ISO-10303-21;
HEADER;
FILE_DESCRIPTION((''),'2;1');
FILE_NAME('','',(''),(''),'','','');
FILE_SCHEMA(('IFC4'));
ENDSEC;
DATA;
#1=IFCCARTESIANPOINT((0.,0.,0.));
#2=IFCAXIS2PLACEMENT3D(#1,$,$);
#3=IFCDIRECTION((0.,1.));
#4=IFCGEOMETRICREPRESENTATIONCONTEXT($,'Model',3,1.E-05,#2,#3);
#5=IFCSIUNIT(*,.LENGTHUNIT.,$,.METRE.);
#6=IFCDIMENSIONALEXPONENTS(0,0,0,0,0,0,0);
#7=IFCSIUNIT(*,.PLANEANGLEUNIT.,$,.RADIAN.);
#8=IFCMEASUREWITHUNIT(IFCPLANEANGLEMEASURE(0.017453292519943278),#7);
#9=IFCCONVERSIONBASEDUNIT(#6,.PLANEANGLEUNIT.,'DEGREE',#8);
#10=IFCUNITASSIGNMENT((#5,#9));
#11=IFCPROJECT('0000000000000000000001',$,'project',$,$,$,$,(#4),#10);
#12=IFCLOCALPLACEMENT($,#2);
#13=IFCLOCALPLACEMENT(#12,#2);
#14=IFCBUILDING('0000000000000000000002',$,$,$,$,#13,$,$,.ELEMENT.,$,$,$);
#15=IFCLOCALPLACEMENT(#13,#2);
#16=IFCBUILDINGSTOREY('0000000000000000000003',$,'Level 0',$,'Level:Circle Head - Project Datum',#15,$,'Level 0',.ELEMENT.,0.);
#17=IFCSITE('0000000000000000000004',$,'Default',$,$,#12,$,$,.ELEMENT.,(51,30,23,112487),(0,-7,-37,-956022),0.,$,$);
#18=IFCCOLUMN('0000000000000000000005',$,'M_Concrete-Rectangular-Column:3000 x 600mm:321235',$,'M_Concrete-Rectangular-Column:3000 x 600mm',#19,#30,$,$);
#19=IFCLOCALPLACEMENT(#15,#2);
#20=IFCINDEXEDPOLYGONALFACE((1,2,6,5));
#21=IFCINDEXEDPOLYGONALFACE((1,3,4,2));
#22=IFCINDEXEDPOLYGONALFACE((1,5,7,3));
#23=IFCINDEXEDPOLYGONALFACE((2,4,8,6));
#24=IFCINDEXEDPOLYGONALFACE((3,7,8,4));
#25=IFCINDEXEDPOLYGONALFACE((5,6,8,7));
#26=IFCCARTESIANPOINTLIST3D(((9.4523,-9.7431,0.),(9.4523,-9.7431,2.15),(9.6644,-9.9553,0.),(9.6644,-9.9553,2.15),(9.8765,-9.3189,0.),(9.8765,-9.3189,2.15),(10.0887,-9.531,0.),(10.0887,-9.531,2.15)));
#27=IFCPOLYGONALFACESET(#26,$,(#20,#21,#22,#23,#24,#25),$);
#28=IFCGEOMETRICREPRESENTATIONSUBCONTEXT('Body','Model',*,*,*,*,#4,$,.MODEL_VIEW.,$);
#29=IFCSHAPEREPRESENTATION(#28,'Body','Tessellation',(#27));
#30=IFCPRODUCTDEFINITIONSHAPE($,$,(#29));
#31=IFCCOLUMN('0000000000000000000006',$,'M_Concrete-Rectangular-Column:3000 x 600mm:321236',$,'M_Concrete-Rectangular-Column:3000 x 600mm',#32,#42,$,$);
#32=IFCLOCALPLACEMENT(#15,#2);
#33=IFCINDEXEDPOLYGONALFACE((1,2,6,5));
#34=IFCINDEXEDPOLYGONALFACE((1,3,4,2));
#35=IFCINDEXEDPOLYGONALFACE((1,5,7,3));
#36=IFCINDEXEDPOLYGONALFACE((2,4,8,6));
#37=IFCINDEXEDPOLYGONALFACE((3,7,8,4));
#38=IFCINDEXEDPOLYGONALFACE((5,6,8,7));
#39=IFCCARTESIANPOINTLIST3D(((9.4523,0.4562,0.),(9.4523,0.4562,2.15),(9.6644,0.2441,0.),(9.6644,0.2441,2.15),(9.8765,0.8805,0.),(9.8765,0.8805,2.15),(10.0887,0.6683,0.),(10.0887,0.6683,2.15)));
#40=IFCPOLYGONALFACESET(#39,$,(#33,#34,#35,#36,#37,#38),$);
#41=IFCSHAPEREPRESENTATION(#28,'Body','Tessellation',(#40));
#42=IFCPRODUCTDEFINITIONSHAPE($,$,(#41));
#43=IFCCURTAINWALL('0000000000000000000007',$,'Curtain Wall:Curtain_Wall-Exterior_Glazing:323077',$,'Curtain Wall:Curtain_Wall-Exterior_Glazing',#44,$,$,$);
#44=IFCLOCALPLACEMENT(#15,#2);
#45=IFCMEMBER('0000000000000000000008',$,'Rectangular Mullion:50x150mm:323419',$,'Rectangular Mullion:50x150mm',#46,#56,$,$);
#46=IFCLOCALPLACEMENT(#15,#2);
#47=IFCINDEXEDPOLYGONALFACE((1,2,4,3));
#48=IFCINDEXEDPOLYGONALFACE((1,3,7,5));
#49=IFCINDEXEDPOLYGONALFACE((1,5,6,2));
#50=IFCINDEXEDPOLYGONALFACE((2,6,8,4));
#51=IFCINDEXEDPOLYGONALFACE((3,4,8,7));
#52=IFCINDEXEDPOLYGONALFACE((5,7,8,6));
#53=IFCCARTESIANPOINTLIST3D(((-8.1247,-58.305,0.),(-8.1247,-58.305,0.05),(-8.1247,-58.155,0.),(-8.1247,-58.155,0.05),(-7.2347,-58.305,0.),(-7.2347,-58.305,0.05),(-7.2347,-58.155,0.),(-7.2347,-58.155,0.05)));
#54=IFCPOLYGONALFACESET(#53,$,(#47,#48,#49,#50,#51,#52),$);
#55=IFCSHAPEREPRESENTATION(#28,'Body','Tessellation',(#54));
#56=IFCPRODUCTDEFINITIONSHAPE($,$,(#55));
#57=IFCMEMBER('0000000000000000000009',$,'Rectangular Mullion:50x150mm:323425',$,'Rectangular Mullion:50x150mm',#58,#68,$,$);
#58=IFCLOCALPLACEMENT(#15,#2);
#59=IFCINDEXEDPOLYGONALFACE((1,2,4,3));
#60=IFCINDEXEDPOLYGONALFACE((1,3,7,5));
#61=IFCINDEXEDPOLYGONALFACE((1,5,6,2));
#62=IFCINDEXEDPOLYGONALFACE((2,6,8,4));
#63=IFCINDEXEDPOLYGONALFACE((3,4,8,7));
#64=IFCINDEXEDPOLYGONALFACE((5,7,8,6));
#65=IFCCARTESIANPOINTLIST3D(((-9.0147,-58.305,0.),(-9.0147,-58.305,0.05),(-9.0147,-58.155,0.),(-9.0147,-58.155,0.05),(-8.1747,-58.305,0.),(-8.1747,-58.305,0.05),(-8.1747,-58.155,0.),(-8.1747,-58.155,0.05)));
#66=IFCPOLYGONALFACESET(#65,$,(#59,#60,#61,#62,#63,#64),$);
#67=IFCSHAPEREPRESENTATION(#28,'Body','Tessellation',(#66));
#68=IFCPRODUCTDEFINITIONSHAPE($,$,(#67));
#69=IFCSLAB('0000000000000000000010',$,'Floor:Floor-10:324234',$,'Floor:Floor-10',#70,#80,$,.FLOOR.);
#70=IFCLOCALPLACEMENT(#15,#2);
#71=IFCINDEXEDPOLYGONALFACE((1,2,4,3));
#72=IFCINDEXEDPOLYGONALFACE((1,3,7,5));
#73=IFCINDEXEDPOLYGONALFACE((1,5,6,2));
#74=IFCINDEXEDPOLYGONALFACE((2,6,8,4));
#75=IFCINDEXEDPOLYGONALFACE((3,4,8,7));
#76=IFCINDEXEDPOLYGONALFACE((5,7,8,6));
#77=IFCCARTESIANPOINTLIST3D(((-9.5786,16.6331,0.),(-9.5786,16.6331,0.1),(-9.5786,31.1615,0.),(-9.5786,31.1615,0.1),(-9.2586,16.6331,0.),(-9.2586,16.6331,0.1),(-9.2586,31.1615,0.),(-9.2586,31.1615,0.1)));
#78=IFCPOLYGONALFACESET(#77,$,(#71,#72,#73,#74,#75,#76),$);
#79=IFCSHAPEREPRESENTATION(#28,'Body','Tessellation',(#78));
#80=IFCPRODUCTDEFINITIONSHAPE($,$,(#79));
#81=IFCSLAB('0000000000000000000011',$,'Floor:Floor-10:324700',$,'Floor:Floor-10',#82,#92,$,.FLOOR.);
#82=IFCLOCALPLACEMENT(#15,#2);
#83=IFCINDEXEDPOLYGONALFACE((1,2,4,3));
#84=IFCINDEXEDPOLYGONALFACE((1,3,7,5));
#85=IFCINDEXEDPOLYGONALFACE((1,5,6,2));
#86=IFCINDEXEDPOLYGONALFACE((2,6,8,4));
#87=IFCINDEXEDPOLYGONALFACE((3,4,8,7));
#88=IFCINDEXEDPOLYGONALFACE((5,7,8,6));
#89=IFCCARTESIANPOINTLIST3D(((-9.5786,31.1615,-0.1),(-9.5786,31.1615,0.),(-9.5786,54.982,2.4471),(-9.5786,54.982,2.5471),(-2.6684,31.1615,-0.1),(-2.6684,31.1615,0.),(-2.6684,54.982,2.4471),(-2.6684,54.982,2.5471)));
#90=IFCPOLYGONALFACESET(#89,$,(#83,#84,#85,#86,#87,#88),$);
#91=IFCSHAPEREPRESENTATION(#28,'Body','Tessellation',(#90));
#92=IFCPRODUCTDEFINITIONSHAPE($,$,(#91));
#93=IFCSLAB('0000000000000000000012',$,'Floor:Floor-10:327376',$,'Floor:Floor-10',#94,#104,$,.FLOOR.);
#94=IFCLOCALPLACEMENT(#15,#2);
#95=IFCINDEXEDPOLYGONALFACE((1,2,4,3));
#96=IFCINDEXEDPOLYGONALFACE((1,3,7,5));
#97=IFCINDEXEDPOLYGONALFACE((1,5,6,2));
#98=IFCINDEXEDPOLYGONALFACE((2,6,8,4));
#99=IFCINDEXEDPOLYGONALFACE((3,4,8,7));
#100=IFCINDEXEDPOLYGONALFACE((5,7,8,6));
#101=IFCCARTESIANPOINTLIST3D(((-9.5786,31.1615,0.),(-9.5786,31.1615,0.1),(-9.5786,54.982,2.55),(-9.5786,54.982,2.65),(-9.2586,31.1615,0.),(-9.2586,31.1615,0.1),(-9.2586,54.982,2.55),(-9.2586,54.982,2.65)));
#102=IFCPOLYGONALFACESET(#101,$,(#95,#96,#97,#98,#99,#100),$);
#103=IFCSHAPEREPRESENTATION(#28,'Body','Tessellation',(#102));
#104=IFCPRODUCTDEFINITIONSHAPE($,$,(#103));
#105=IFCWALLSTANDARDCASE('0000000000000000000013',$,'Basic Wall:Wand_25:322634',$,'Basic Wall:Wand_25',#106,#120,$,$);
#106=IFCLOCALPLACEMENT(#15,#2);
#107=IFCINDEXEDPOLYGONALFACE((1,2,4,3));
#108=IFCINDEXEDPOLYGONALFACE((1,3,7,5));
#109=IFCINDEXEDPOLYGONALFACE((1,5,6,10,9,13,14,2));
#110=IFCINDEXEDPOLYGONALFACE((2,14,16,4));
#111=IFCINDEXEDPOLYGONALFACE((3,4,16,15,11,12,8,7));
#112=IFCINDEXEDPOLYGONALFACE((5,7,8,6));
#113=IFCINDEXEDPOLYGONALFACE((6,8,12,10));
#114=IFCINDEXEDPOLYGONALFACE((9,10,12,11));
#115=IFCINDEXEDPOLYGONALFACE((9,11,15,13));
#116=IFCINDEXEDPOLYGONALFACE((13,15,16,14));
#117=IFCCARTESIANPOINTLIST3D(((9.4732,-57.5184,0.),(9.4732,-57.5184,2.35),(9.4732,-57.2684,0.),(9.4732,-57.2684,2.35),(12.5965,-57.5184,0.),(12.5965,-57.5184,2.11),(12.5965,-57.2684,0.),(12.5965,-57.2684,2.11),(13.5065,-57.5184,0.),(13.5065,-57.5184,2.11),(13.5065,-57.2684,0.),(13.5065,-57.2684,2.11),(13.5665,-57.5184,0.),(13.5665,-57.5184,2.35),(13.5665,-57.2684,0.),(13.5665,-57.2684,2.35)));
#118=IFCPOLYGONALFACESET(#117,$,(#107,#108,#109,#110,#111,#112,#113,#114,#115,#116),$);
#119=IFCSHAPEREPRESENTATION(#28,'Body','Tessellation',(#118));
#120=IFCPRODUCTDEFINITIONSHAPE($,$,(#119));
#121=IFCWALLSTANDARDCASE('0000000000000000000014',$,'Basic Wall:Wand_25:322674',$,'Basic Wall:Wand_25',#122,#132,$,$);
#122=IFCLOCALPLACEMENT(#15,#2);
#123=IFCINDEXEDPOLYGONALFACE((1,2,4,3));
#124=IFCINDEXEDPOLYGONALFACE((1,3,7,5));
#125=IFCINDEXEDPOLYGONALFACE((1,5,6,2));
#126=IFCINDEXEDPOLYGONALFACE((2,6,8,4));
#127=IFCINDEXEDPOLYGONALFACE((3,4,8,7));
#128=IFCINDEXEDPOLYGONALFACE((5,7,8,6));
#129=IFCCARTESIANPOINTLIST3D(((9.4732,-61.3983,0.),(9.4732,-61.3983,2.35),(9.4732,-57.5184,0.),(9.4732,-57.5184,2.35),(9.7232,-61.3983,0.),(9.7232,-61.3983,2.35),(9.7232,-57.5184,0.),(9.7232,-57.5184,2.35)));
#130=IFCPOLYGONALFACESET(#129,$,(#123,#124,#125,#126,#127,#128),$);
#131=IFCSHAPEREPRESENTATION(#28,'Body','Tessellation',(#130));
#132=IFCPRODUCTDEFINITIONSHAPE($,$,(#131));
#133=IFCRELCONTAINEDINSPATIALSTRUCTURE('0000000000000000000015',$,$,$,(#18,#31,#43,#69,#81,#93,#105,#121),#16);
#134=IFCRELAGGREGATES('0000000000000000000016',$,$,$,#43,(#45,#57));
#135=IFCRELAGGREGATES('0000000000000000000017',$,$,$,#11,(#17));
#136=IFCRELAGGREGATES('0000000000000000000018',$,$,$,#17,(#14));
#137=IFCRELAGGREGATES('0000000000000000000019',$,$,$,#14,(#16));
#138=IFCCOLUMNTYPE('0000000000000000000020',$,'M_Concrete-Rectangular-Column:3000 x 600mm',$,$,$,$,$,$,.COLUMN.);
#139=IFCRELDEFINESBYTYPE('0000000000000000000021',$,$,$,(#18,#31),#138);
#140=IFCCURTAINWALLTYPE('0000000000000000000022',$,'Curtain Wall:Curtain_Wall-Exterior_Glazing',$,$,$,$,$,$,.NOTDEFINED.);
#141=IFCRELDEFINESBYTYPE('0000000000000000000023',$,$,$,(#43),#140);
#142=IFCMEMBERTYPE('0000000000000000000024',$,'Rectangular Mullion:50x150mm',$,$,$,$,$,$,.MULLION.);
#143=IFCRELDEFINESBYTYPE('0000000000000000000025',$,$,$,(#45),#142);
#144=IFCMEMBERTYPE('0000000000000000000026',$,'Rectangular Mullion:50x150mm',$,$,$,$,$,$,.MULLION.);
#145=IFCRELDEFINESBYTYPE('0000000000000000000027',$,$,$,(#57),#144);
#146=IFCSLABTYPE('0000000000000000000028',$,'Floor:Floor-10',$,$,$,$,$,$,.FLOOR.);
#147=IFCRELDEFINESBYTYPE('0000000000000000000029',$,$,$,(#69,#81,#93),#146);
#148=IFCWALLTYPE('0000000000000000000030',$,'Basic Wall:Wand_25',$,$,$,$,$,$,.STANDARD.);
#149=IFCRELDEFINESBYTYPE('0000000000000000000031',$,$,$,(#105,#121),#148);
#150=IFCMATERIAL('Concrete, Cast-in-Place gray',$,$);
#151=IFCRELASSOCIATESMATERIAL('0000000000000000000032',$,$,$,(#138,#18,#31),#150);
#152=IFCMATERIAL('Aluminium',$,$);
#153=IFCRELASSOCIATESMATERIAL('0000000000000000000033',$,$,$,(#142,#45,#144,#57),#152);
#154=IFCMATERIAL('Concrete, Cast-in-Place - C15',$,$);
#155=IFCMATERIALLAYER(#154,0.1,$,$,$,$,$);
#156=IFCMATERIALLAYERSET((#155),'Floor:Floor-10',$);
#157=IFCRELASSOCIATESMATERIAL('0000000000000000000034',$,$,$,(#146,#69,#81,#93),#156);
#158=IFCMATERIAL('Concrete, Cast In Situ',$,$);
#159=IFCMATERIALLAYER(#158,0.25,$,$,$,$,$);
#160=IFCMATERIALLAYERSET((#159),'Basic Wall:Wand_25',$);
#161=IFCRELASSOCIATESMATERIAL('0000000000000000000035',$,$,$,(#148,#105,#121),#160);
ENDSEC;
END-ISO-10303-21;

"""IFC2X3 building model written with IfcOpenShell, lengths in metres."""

from ifc_helpers import new_model, entity, si_unit, converted_unit, direction, frame, frame_2d, origin, origin_2d_with_axis, place, context, subcontext, project, spatial, rectangle, extrude, clip, halfspace, source, transform, mapped, material, layer, layer_set, layer_usage, type_object, type_shapes, element, aggregate, save


model = new_model("IFC2X3")

# Units and contexts
model_context = context("Model", 3, precision=1e-05, world=origin(), true_north=direction((0.0, 1.0)))
body_context = subcontext(model_context, "Body", "Model", "MODEL_VIEW")
ifc_project = project(units=[si_unit("LENGTHUNIT", "METRE"), converted_unit("PLANEANGLEUNIT", "DEGREE", entity("IfcPlaneAngleMeasure", 0.017453292519943278), si_unit("PLANEANGLEUNIT", "RADIAN"), dimensions=[0, 0, 0, 0, 0, 0, 0])], contexts=[model_context])

# Site, building, storey
site_placement = place(None, origin())
site = spatial("IfcSite", under=ifc_project, at=site_placement, Name="Default", CompositionType="ELEMENT", RefLatitude=(51, 30, 23, 112487), RefLongitude=(0, -7, -37, -956022), RefElevation=0.0)
building_placement = place(site_placement, origin())
building = spatial("IfcBuilding", under=site, at=building_placement, CompositionType="ELEMENT")
storey_placement = place(building_placement, origin())
storey = spatial("IfcBuildingStorey", under=building, at=storey_placement, Name="Level 0", ObjectType="Level:Circle Head - Project Datum", LongName="Level 0", CompositionType="ELEMENT", Elevation=0.0)

# Columns
ifc_material_1 = material(Name="Concrete, Cast-in-Place gray")
column_type = type_object("IfcColumnType", Name="M_Concrete-Rectangular-Column:3000 x 600mm", PredefinedType="COLUMN", material=ifc_material_1)
shared_shape_1 = source(origin(), body_context, "Body", "SweptSolid", [
    extrude(rectangle(XDim=0.3, YDim=0.6, at=origin_2d_with_axis()), frame((0.0, 0.0, 0.0), z_axis=(0.0, 0.0, 1.0), x_axis=(-1.0, 0.0, 0.0)), (0.0, 0.0, 1.0), 2.15),
])
type_shapes(column_type, [shared_shape_1])
for number, where, z_axis, x_axis, name in (
    (1, (9.7705, -9.6371, 0.0), (0.0, 0.0, 1.0), (0.707107, -0.707107, 0.0), "M_Concrete-Rectangular-Column:3000 x 600mm:321235"),
    (2, (9.7705, 0.5623, 0.0), (0.0, 0.0, 1.0), (0.707107, -0.707107, 0.0), "M_Concrete-Rectangular-Column:3000 x 600mm:321236"),
):
    element("IfcColumn", number, at=place(storey_placement, frame(where, z_axis=z_axis, x_axis=x_axis)), inside=storey, type_object=column_type, material=ifc_material_1, Name=name, ObjectType="M_Concrete-Rectangular-Column:3000 x 600mm", context=body_context, shape_type="MappedRepresentation", body=[
        mapped(shared_shape_1, transform((0.0, 0.0, 0.0), scale=1.0)),
    ])

# Curtain wall, members
curtain_wall_type = type_object("IfcCurtainWallType", Name="Curtain Wall:Curtain_Wall-Exterior_Glazing", PredefinedType="NOTDEFINED")
curtain_wall_placement = place(storey_placement, origin())
curtain_wall = element("IfcCurtainWall", 3, at=curtain_wall_placement, inside=storey, type_object=curtain_wall_type, Name="Curtain Wall:Curtain_Wall-Exterior_Glazing:323077", ObjectType="Curtain Wall:Curtain_Wall-Exterior_Glazing")
ifc_material_2 = material(Name="Aluminium")
member_type_1 = type_object("IfcMemberType", Name="Rectangular Mullion:50x150mm", PredefinedType="MULLION", material=ifc_material_2)
shared_shape_2 = source(origin(), body_context, "Body", "SweptSolid", [
    extrude(rectangle(XDim=0.05, YDim=0.15, at=origin_2d_with_axis()), frame((-0.025, 0.0, -0.89), z_axis=(0.0, 0.0, 1.0), x_axis=(-1.0, 0.0, 0.0)), (0.0, 0.0, 1.0), 0.89),
])
type_shapes(member_type_1, [shared_shape_2])
member_1_placement = place(curtain_wall_placement, frame((-8.1247, -58.23, 0.0), z_axis=(-1.0, 0.0, 0.0), x_axis=(0.0, 0.0, -1.0)))
member_1 = element("IfcMember", 4, at=member_1_placement, type_object=member_type_1, material=ifc_material_2, Name="Rectangular Mullion:50x150mm:323419", ObjectType="Rectangular Mullion:50x150mm", context=body_context, shape_type="MappedRepresentation", body=[
    mapped(shared_shape_2, transform((0.0, 0.0, 0.0), scale=1.0)),
])
member_type_2 = type_object("IfcMemberType", Name="Rectangular Mullion:50x150mm", PredefinedType="MULLION", material=ifc_material_2)
shared_shape_3 = source(origin(), body_context, "Body", "SweptSolid", [
    extrude(rectangle(XDim=0.05, YDim=0.15, at=origin_2d_with_axis()), frame((-0.025, 0.0, -0.84), z_axis=(0.0, 0.0, 1.0), x_axis=(-1.0, 0.0, 0.0)), (0.0, 0.0, 1.0), 0.84),
])
type_shapes(member_type_2, [shared_shape_3])
member_2_placement = place(curtain_wall_placement, frame((-9.0147, -58.23, 0.0), z_axis=(-1.0, 0.0, 0.0), x_axis=(0.0, 0.0, -1.0)))
member_2 = element("IfcMember", 5, at=member_2_placement, type_object=member_type_2, material=ifc_material_2, Name="Rectangular Mullion:50x150mm:323425", ObjectType="Rectangular Mullion:50x150mm", context=body_context, shape_type="MappedRepresentation", body=[
    mapped(shared_shape_3, transform((0.0, 0.0, 0.0), scale=1.0)),
])
aggregate(curtain_wall, [member_1, member_2])

# Slabs
ifc_material_3 = material(Name="Concrete, Cast-in-Place - C15")
ifc_layer_1 = layer(ifc_material_3, 0.1)
ifc_layer_set_1 = layer_set([ifc_layer_1], Name="Floor:Floor-10")
ifc_layer_usage_1 = layer_usage(ifc_layer_set_1, "AXIS3", "POSITIVE", 0.0)
slab_type_1 = type_object("IfcSlabType", Name="Floor:Floor-10", PredefinedType="FLOOR", material=ifc_layer_set_1)
slab_1_placement = place(storey_placement, origin())
element("IfcSlab", 6, at=slab_1_placement, inside=storey, type_object=slab_type_1, material=ifc_layer_usage_1, Name="Floor:Floor-10:324234", ObjectType="Floor:Floor-10", PredefinedType="FLOOR", context=body_context, shape_type="SweptSolid", body=[
    extrude(rectangle(XDim=14.5284, YDim=0.32, at=frame_2d((0.0, 0.0), x_axis=(1.0, 0.0))), frame((-9.4186, 23.8973, 0.1), z_axis=(0.0, 0.0, -1.0), x_axis=(0.0, 1.0, 0.0)), (0.0, 0.0, 1.0), 0.1),
])
slab_2_placement = place(storey_placement, origin())
element("IfcSlab", 7, at=slab_2_placement, inside=storey, type_object=slab_type_1, material=ifc_layer_usage_1, Name="Floor:Floor-10:324700", ObjectType="Floor:Floor-10", PredefinedType="FLOOR", context=body_context, shape_type="SweptSolid", body=[
    clip(clip(extrude(rectangle(XDim=23.9563, YDim=6.9102, at=frame_2d((0.0, 0.0), x_axis=(1.0, 0.0))), frame((-6.1235, 43.0717, 1.2736), z_axis=(0.0, 0.106324, -0.994331), x_axis=(0.0, 0.994331, 0.106324)), (-0.106324, 0.0, 0.994331), 0.1006), halfspace(frame((-6.1235, 43.0717, 1.1736), z_axis=(0.0, 0.106324, -0.994331), x_axis=(-1.0, 0.0, 0.0)), False)), halfspace(frame((-6.1235, 43.0717, 1.2736), z_axis=(0.0, -0.106324, 0.994331), x_axis=(-1.0, 0.0, 0.0)), False)),
])
slab_3_placement = place(storey_placement, origin())
element("IfcSlab", 8, at=slab_3_placement, inside=storey, type_object=slab_type_1, material=ifc_layer_usage_1, Name="Floor:Floor-10:327376", ObjectType="Floor:Floor-10", PredefinedType="FLOOR", context=body_context, shape_type="SweptSolid", body=[
    clip(clip(extrude(rectangle(XDim=23.9566, YDim=0.32, at=frame_2d((0.0, 0.0), x_axis=(1.0, 0.0))), frame((-9.4186, 43.0717, 1.375), z_axis=(0.0, 0.106443, -0.994319), x_axis=(0.0, 0.994319, 0.106443)), (-0.106443, 0.0, 0.994319), 0.1006), halfspace(frame((-9.4186, 43.0717, 1.275), z_axis=(0.0, 0.106443, -0.994319), x_axis=(0.0, 0.994319, 0.106443)), False)), halfspace(frame((-9.4186, 43.0717, 1.375), z_axis=(0.0, -0.106443, 0.994319), x_axis=(0.0, 0.994319, 0.106443)), False)),
])

# Wall, opening
ifc_material_4 = material(Name="Concrete, Cast In Situ")
ifc_layer_2 = layer(ifc_material_4, 0.25)
ifc_layer_set_2 = layer_set([ifc_layer_2], Name="Basic Wall:Wand_25")
ifc_layer_usage_2 = layer_usage(ifc_layer_set_2, "AXIS2", "NEGATIVE", 0.125)
wall_type = type_object("IfcWallType", Name="Basic Wall:Wand_25", PredefinedType="STANDARD", material=ifc_layer_set_2)
wall_1_placement = place(storey_placement, frame((13.5665, -57.3934, 0.0), z_axis=(0.0, 0.0, 1.0), x_axis=(-1.0, 0.0, 0.0)))
wall_1 = element("IfcWallStandardCase", 9, at=wall_1_placement, inside=storey, type_object=wall_type, material=ifc_layer_usage_2, Name="Basic Wall:Wand_25:322634", ObjectType="Basic Wall:Wand_25", context=body_context, shape_type="SweptSolid", body=[
    extrude(rectangle(XDim=4.0933, YDim=0.25, at=frame_2d((2.0466, 0.0), x_axis=(1.0, 0.0))), origin(), (0.0, 0.0, 1.0), 2.35),
])
opening_placement = place(wall_1_placement, frame((0.97, 0.125, 0.0)))
element("IfcOpeningElement", 10, at=opening_placement, cuts=wall_1, ObjectType="Opening", context=body_context, shape_type="SweptSolid", body=[
    extrude(rectangle(XDim=2.11, YDim=0.91, at=frame_2d((1.055, 0.455), x_axis=(1.0, 0.0))), frame((0.0, 0.0, 0.0), z_axis=(0.0, -1.0, 0.0), x_axis=(0.0, 0.0, 1.0)), (0.0, 0.0, 1.0), 0.25),
])

# Wall
wall_2_placement = place(storey_placement, frame((9.5982, -57.5184, 0.0), z_axis=(0.0, 0.0, 1.0), x_axis=(0.0, -1.0, 0.0)))
element("IfcWallStandardCase", 11, at=wall_2_placement, inside=storey, type_object=wall_type, material=ifc_layer_usage_2, Name="Basic Wall:Wand_25:322674", ObjectType="Basic Wall:Wand_25", context=body_context, shape_type="SweptSolid", body=[
    extrude(rectangle(XDim=3.88, YDim=0.25, at=frame_2d((1.94, 0.0), x_axis=(-1.0, 0.0))), origin(), (0.0, 0.0, 1.0), 2.35),
])

save(model, "model.ifc")
